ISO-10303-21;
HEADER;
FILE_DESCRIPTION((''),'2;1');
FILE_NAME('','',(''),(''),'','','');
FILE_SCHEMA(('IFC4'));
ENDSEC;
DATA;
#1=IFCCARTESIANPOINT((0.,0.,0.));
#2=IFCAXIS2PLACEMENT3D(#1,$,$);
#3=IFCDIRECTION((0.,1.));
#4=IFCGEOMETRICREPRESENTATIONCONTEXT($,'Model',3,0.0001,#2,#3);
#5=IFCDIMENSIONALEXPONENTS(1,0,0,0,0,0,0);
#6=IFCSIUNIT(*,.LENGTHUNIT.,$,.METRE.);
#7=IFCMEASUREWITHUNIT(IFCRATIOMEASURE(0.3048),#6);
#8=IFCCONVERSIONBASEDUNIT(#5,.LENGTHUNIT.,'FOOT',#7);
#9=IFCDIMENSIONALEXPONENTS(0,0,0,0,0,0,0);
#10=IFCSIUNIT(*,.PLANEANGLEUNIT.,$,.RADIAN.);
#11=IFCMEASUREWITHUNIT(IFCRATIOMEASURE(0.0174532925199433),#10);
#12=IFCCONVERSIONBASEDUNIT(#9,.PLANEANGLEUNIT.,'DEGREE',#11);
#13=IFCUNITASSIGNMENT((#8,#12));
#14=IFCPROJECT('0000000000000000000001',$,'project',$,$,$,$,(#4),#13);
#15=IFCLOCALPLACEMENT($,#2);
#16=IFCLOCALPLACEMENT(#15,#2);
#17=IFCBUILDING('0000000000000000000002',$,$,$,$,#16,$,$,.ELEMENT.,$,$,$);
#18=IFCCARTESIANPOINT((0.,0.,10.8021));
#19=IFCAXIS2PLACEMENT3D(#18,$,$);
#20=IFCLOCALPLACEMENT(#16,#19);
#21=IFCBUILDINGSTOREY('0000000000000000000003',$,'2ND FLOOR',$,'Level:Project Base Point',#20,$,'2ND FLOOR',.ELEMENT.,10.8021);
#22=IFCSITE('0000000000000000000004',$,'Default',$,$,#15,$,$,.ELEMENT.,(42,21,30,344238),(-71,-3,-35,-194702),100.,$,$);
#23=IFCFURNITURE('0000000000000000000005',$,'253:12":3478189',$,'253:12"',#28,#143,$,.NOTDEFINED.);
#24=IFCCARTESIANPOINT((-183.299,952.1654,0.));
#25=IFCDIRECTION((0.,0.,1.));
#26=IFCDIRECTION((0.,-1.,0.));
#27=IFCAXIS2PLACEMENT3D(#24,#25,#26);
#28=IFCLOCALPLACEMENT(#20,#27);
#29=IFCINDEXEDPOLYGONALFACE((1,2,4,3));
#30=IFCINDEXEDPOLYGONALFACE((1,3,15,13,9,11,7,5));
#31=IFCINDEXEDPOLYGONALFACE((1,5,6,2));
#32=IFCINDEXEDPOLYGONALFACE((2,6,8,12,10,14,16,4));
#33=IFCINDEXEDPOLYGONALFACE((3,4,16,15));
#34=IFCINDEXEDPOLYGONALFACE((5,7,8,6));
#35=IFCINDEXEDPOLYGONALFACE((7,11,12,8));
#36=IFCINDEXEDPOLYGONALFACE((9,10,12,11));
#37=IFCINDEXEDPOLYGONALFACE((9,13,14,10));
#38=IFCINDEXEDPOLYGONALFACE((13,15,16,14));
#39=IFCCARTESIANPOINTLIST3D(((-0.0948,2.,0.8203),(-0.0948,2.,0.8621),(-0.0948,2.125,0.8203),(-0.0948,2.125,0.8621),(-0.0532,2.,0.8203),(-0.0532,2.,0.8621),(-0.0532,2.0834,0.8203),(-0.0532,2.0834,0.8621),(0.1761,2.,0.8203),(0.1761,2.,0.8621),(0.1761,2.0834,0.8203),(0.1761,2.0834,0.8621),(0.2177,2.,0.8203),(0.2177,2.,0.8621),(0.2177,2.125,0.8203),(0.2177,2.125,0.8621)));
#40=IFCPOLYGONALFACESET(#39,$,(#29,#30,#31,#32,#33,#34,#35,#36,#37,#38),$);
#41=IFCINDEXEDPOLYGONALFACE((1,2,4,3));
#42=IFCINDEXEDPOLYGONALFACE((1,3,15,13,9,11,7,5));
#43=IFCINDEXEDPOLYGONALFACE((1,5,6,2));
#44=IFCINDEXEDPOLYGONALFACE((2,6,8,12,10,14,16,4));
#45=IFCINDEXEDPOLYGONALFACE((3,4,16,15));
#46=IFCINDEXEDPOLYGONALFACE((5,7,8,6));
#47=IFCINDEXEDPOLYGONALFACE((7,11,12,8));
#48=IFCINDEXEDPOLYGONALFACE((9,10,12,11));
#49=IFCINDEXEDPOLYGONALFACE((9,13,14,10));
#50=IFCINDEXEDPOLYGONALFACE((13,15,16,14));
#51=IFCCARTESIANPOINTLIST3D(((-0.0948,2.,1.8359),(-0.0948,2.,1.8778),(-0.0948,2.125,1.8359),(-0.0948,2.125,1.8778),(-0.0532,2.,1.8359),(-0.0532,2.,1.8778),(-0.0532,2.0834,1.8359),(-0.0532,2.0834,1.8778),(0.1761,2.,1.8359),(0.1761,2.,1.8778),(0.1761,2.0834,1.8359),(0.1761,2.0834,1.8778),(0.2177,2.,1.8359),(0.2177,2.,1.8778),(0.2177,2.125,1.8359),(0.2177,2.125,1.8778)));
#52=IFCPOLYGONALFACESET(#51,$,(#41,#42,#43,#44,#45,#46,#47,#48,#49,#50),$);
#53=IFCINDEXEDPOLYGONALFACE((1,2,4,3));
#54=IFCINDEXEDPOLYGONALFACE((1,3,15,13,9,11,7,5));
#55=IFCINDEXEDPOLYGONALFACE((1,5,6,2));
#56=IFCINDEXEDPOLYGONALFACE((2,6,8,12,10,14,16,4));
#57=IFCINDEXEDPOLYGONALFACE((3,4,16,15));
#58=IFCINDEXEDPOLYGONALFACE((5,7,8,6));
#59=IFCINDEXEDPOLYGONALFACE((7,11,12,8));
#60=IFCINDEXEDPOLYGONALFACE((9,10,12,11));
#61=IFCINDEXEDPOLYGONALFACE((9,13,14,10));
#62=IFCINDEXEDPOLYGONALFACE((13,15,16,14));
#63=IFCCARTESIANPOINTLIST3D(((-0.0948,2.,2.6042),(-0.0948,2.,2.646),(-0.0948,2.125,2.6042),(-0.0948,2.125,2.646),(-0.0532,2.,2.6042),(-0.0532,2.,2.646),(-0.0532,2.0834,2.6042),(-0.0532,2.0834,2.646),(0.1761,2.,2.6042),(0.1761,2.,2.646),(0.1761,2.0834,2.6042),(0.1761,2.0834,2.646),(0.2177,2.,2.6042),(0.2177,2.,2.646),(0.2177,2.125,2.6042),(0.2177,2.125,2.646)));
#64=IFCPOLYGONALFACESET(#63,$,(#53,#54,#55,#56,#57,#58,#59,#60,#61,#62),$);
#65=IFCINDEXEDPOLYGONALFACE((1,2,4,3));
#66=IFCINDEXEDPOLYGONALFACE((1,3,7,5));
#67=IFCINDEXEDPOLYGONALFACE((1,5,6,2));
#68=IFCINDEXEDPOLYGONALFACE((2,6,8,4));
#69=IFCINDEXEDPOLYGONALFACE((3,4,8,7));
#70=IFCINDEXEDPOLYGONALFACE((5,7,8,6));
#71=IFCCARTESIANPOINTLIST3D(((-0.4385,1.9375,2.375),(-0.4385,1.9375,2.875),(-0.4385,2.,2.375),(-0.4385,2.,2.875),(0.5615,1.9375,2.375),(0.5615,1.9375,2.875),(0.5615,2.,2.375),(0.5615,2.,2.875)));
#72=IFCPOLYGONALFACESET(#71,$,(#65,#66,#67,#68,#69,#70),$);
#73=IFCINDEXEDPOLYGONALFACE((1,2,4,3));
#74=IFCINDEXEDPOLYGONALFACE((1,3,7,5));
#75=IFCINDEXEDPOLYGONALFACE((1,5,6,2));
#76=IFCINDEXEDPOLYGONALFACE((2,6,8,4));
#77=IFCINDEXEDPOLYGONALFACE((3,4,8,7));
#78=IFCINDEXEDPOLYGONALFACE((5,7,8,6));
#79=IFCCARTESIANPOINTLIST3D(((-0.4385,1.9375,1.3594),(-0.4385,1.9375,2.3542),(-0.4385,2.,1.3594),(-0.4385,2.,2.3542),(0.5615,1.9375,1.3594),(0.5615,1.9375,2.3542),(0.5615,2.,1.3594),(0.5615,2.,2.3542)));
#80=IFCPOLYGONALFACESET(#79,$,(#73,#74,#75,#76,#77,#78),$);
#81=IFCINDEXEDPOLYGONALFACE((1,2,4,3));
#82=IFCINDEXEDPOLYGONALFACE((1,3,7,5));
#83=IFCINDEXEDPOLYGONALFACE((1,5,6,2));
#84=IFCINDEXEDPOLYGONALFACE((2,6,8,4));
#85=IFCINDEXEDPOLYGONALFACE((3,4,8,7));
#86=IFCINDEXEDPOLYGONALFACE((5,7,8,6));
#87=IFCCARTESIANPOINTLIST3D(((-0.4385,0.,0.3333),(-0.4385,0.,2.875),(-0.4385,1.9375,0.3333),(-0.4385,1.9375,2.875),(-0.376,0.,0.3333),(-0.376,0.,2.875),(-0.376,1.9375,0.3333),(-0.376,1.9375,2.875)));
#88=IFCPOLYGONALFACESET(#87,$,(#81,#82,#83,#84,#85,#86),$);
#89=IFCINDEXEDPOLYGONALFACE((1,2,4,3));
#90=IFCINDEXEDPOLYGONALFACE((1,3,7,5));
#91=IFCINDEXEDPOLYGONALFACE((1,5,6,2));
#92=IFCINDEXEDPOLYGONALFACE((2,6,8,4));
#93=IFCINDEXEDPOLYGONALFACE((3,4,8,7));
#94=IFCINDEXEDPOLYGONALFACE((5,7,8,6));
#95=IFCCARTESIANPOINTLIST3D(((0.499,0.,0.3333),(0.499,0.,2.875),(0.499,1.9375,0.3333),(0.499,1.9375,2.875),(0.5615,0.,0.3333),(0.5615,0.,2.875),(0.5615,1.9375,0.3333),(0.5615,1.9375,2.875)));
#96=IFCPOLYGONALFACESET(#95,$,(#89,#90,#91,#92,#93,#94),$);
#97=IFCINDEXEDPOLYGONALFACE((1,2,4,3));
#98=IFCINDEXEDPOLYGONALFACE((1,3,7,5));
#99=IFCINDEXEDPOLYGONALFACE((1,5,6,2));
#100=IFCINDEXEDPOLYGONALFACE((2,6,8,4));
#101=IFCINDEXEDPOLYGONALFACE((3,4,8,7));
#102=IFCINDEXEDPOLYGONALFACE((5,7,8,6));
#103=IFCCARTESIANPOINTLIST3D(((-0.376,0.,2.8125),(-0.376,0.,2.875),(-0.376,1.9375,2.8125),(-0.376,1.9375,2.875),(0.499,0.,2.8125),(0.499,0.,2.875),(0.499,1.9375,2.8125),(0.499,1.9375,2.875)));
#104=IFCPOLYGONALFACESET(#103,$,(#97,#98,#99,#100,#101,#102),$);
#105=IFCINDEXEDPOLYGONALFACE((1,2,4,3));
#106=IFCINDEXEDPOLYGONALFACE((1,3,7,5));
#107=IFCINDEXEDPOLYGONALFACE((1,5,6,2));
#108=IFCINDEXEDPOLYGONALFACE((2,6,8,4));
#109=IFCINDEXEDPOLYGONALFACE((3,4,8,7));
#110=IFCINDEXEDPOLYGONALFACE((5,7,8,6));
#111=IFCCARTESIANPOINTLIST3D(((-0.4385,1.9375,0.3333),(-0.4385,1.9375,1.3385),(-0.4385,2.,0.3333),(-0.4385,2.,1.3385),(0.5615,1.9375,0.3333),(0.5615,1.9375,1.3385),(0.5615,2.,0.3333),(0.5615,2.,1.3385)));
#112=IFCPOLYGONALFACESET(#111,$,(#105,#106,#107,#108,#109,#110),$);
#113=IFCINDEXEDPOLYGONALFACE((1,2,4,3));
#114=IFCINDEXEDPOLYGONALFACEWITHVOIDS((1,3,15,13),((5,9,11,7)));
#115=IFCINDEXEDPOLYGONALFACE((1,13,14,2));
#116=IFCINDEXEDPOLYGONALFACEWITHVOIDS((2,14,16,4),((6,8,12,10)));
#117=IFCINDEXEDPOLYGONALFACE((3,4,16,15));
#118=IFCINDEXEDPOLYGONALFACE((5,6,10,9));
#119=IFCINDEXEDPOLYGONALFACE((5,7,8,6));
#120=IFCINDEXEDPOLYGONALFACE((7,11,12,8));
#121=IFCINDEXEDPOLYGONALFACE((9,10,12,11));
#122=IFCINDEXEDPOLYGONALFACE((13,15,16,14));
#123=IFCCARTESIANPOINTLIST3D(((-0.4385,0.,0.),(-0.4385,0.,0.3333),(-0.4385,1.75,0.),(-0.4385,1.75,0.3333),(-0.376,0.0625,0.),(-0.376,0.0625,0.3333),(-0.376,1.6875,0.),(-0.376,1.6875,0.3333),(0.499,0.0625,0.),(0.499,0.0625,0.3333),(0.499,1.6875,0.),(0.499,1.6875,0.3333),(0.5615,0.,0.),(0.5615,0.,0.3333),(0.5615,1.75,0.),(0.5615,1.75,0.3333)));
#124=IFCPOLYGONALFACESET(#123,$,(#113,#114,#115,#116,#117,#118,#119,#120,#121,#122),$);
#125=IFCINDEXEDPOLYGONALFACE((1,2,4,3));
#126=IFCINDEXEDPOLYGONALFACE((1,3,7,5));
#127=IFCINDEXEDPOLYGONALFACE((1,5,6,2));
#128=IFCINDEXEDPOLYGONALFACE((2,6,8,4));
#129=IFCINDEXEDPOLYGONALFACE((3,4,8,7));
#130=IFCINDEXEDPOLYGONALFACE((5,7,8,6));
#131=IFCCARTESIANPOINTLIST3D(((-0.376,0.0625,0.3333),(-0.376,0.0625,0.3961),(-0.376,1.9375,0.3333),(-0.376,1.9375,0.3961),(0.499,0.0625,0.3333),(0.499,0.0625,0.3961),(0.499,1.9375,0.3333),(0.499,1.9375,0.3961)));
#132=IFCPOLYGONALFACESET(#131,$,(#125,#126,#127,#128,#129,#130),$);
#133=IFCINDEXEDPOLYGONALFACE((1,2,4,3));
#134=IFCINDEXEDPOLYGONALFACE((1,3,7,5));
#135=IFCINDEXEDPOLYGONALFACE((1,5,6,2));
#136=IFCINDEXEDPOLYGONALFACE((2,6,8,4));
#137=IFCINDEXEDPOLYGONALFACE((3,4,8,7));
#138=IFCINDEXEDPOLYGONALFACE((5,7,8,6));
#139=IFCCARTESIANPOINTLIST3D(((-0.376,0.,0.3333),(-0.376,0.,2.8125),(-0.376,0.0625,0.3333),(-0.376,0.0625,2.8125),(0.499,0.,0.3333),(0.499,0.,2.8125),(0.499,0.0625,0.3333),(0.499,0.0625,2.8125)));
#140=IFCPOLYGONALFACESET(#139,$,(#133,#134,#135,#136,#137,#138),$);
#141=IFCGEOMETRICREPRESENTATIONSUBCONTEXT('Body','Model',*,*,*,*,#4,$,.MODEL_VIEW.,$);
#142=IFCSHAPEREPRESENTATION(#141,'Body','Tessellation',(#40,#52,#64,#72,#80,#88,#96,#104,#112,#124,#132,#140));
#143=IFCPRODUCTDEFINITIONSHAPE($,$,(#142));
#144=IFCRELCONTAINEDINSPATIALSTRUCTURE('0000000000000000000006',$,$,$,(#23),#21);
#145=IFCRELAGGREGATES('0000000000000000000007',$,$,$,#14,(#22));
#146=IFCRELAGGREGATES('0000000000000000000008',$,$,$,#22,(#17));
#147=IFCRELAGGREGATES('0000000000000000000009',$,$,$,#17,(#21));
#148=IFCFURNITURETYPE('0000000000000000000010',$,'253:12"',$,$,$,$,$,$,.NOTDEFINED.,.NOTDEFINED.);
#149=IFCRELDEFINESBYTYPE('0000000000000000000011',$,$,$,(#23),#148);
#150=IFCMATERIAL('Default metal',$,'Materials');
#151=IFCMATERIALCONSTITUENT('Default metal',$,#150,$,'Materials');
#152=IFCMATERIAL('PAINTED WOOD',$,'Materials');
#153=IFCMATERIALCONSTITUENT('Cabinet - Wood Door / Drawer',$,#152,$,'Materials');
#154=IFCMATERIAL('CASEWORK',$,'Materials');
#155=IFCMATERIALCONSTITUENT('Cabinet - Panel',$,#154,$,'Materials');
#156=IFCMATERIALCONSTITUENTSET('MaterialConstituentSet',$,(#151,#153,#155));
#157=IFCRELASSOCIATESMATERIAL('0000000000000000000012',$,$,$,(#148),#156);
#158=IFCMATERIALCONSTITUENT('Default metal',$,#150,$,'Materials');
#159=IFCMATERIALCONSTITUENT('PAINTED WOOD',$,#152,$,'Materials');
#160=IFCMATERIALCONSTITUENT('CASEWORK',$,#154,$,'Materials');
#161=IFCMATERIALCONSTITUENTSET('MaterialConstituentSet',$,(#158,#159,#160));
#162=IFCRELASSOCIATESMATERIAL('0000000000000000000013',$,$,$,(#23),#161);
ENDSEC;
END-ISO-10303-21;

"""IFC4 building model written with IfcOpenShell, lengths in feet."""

from ifc_helpers import new_model, entity, si_unit, converted_unit, direction, frame, frame_2d, origin, origin_2d_with_axis, place, context, subcontext, project, spatial, polyline, rectangle, outline, extrude, source, transform, mapped, material, constituent, constituent_set, type_object, type_shapes, element, save


model = new_model("IFC4")

# Units and contexts
model_context = context("Model", 3, precision=0.0001, world=origin(), true_north=direction((0.0, 1.0)))
body_context = subcontext(model_context, "Body", "Model", "MODEL_VIEW")
ifc_project = project(units=[converted_unit("LENGTHUNIT", "FOOT", entity("IfcRatioMeasure", 0.3048), si_unit("LENGTHUNIT", "METRE"), dimensions=[1, 0, 0, 0, 0, 0, 0]), converted_unit("PLANEANGLEUNIT", "DEGREE", entity("IfcRatioMeasure", 0.0174532925199433), si_unit("PLANEANGLEUNIT", "RADIAN"), dimensions=[0, 0, 0, 0, 0, 0, 0])], contexts=[model_context])

# Site, building, storey
site_placement = place(None, origin())
site = spatial("IfcSite", under=ifc_project, at=site_placement, Name="Default", CompositionType="ELEMENT", RefLatitude=(42, 21, 30, 344238), RefLongitude=(-71, -3, -35, -194702), RefElevation=100.0)
building_placement = place(site_placement, origin())
building = spatial("IfcBuilding", under=site, at=building_placement, CompositionType="ELEMENT")
storey_placement = place(building_placement, frame((0.0, 0.0, 10.8021)))
storey = spatial("IfcBuildingStorey", under=building, at=storey_placement, Name="2ND FLOOR", ObjectType="Level:Project Base Point", LongName="2ND FLOOR", CompositionType="ELEMENT", Elevation=10.8021)

# Furniture
ifc_material_1 = material(Name="Default metal", Category="Materials")
ifc_constituent_1 = constituent(ifc_material_1, Name="Default metal", Category="Materials")
ifc_material_2 = material(Name="PAINTED WOOD", Category="Materials")
ifc_constituent_2 = constituent(ifc_material_2, Name="PAINTED WOOD", Category="Materials")
ifc_material_3 = material(Name="CASEWORK", Category="Materials")
ifc_constituent_3 = constituent(ifc_material_3, Name="CASEWORK", Category="Materials")
ifc_constituent_set_1 = constituent_set(constituents=[ifc_constituent_1, ifc_constituent_2, ifc_constituent_3], Name="MaterialConstituentSet")
ifc_constituent_4 = constituent(ifc_material_1, Name="Default metal", Category="Materials")
ifc_constituent_5 = constituent(ifc_material_2, Name="Cabinet - Wood Door / Drawer", Category="Materials")
ifc_constituent_6 = constituent(ifc_material_3, Name="Cabinet - Panel", Category="Materials")
ifc_constituent_set_2 = constituent_set(constituents=[ifc_constituent_4, ifc_constituent_5, ifc_constituent_6], Name="MaterialConstituentSet")
furniture_type_1 = type_object("IfcFurnitureType", Name="253:12\"", AssemblyPlace="NOTDEFINED", PredefinedType="NOTDEFINED", material=ifc_constituent_set_2)
shared_shape_1 = source(origin(), body_context, "Body", "SweptSolid", [
    extrude(outline(polyline([(-0.1562, -0.0521), (-0.1146, -0.0521), (-0.1146, 0.0313), (0.1146, 0.0313), (0.1146, -0.0521), (0.1562, -0.0521), (0.1562, 0.0729), (-0.1562, 0.0729), (-0.1562, -0.0521)])), frame((0.0615, 2.0521, 0.8203)), (0.0, 0.0, 1.0), 0.0418),
    extrude(outline(polyline([(-0.1562, -0.0521), (-0.1146, -0.0521), (-0.1146, 0.0313), (0.1146, 0.0313), (0.1146, -0.0521), (0.1562, -0.0521), (0.1562, 0.0729), (-0.1562, 0.0729), (-0.1562, -0.0521)])), frame((0.0615, 2.0521, 1.8359)), (0.0, 0.0, 1.0), 0.0418),
    extrude(outline(polyline([(-0.1562, -0.0521), (-0.1146, -0.0521), (-0.1146, 0.0313), (0.1146, 0.0313), (0.1146, -0.0521), (0.1562, -0.0521), (0.1562, 0.0729), (-0.1562, 0.0729), (-0.1562, -0.0521)])), frame((0.0615, 2.0521, 2.6042)), (0.0, 0.0, 1.0), 0.0418),
    extrude(rectangle(XDim=1.0, YDim=0.0625, at=frame_2d((0.0, 0.0), x_axis=(1.0, 0.0))), frame((0.0615, 1.9688, 2.375), z_axis=(0.0, 0.0, 1.0), x_axis=(-1.0, 0.0, 0.0)), (0.0, 0.0, 1.0), 0.5),
    extrude(rectangle(XDim=1.0, YDim=0.0625, at=frame_2d((0.0, 0.0), x_axis=(1.0, 0.0))), frame((0.0615, 1.9688, 1.3594), z_axis=(0.0, 0.0, 1.0), x_axis=(-1.0, 0.0, 0.0)), (0.0, 0.0, 1.0), 0.9948),
    extrude(rectangle(XDim=1.9375, YDim=0.0625, at=frame_2d((0.0, 0.0), x_axis=(1.0, 0.0))), frame((-0.4073, 0.9687, 0.3333), z_axis=(0.0, 0.0, 1.0), x_axis=(0.0, -1.0, 0.0)), (0.0, 0.0, 1.0), 2.5417),
    extrude(rectangle(XDim=1.9375, YDim=0.0625, at=frame_2d((0.0, 0.0), x_axis=(1.0, 0.0))), frame((0.5302, 0.9687, 0.3333), z_axis=(0.0, 0.0, 1.0), x_axis=(0.0, -1.0, 0.0)), (0.0, 0.0, 1.0), 2.5417),
    extrude(rectangle(XDim=1.9375, YDim=0.875, at=origin_2d_with_axis()), frame((0.0615, 0.9688, 2.8125), z_axis=(0.0, 0.0, 1.0), x_axis=(0.0, 1.0, 0.0)), (0.0, 0.0, 1.0), 0.0625),
    extrude(rectangle(XDim=1.0, YDim=0.0625, at=frame_2d((0.0, 0.0), x_axis=(1.0, 0.0))), frame((0.0615, 1.9688, 0.3333), z_axis=(0.0, 0.0, 1.0), x_axis=(-1.0, 0.0, 0.0)), (0.0, 0.0, 1.0), 1.0052),
    extrude(outline(polyline([(-0.875, -0.5), (0.875, -0.5), (0.875, 0.5), (-0.875, 0.5), (-0.875, -0.5)]), holes=[polyline([(-0.8125, -0.4375), (-0.8125, 0.4375), (0.8125, 0.4375), (0.8125, -0.4375), (-0.8125, -0.4375)])]), frame((0.0615, 0.875, 0.0), z_axis=(0.0, 0.0, 1.0), x_axis=(0.0, -1.0, 0.0)), (0.0, 0.0, 1.0), 0.3333),
    extrude(rectangle(XDim=1.875, YDim=0.875, at=origin_2d_with_axis()), frame((0.0615, 1.0, 0.3333), z_axis=(0.0, 0.0, 1.0), x_axis=(0.0, 1.0, 0.0)), (0.0, 0.0, 1.0), 0.0627),
    extrude(rectangle(XDim=0.875, YDim=0.0625, at=origin_2d_with_axis()), frame((0.0615, 0.0312, 0.3333), z_axis=(0.0, 0.0, 1.0), x_axis=(-1.0, 0.0, 0.0)), (0.0, 0.0, 1.0), 2.4792),
])
type_shapes(furniture_type_1, [shared_shape_1])
furniture_1_placement = place(storey_placement, frame((-183.299, 952.1654, 0.0), z_axis=(0.0, 0.0, 1.0), x_axis=(0.0, -1.0, 0.0)))
element("IfcFurniture", 1, at=furniture_1_placement, inside=storey, type_object=furniture_type_1, material=ifc_constituent_set_1, Name="253:12\":3478189", ObjectType="253:12\"", PredefinedType="NOTDEFINED", context=body_context, shape_type="MappedRepresentation", body=[
    mapped(shared_shape_1, transform((0.0, 0.0, 0.0), scale=1.0)),
])

save(model, "model.ifc")
